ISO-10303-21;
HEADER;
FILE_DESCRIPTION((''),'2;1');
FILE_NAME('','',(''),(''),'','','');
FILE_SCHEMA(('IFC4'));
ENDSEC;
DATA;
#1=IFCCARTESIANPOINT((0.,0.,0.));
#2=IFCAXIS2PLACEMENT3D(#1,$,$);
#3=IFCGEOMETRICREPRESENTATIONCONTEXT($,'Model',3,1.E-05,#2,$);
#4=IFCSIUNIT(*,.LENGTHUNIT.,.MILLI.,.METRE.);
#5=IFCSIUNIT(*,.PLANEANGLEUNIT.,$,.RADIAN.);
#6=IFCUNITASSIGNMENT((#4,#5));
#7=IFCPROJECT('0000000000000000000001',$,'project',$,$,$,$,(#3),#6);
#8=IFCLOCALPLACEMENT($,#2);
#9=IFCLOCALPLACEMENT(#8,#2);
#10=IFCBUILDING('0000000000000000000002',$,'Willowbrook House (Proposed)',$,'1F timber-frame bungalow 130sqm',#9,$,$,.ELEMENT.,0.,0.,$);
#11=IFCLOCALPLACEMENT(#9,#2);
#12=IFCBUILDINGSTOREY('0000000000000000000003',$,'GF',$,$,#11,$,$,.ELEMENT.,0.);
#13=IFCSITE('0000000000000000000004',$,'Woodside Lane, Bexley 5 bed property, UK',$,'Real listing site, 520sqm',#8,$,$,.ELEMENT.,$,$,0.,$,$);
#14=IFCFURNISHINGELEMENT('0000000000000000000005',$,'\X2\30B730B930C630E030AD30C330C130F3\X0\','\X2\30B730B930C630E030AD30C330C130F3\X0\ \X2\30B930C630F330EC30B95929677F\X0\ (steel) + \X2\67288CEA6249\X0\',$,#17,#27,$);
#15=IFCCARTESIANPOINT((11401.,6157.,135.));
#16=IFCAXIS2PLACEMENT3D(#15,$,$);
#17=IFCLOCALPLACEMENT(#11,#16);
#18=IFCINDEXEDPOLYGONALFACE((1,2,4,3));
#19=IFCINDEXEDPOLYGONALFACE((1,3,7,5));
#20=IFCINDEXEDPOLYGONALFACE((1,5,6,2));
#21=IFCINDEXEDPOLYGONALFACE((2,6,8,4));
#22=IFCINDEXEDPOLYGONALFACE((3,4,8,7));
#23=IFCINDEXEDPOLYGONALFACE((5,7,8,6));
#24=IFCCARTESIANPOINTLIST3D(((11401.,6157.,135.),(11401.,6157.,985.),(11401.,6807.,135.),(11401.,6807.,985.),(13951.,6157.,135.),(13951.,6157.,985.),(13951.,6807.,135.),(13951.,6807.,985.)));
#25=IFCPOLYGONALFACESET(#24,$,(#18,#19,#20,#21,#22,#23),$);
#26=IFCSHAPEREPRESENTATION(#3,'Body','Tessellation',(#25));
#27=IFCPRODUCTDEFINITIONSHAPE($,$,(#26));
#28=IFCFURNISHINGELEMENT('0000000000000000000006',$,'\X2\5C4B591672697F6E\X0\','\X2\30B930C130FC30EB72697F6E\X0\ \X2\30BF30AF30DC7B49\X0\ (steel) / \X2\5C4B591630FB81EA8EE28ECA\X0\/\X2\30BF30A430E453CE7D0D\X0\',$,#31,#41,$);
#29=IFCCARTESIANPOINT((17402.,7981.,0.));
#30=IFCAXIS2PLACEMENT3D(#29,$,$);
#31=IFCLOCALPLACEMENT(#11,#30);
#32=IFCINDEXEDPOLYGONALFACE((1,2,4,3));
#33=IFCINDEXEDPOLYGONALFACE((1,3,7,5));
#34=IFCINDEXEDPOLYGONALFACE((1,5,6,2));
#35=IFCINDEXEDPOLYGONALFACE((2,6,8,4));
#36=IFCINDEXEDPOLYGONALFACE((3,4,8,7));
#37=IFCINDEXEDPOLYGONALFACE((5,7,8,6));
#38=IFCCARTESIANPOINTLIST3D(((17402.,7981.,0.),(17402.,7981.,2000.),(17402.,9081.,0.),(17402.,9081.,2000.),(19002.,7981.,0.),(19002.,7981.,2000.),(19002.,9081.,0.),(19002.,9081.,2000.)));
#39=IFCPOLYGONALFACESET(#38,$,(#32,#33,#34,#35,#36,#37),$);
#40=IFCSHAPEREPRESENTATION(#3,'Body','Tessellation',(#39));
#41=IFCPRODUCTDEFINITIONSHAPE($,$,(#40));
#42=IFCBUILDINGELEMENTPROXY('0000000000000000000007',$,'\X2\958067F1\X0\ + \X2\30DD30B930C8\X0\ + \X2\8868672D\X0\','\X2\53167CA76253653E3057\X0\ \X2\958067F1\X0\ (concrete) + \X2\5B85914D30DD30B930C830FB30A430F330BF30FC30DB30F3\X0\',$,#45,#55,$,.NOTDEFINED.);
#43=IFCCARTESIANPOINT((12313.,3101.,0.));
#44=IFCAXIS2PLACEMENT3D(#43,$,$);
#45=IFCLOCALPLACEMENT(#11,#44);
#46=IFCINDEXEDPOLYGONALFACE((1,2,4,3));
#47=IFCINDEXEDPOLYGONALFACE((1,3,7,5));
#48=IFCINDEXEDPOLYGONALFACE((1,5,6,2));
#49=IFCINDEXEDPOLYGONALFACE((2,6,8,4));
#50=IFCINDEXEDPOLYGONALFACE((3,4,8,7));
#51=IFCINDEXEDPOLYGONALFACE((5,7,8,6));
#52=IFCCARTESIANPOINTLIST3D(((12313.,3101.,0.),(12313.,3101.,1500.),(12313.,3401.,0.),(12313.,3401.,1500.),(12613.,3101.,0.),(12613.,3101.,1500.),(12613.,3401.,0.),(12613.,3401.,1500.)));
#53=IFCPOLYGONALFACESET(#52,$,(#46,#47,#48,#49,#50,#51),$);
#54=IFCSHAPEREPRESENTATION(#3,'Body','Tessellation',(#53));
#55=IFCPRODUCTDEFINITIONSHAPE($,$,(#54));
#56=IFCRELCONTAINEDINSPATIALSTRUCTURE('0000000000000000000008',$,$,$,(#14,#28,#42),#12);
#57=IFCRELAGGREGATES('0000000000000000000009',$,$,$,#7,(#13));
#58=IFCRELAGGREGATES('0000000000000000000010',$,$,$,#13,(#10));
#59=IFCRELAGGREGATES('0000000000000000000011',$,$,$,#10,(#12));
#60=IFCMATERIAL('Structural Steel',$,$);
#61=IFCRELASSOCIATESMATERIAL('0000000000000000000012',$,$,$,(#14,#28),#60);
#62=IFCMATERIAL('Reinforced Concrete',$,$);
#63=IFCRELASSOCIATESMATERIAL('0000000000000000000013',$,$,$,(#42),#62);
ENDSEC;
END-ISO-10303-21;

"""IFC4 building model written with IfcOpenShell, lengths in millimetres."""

from ifc_helpers import new_model, si_unit, frame, frame_2d, origin, place, context, project, spatial, rectangle, extrude, material, element, save


model = new_model("IFC4")

# Units and contexts
model_context = context("Model", 3, precision=1e-05, world=origin())
ifc_project = project(units=[si_unit("LENGTHUNIT", "METRE", prefix="MILLI"), si_unit("PLANEANGLEUNIT", "RADIAN")], contexts=[model_context])

# Site, building, storey
site_placement = place(None, origin())
site = spatial("IfcSite", under=ifc_project, at=site_placement, Name="Woodside Lane, Bexley 5 bed property, UK", ObjectType="Real listing site, 520sqm", CompositionType="ELEMENT", RefElevation=0.0)
building_placement = place(site_placement, origin())
building = spatial("IfcBuilding", under=site, at=building_placement, Name="Willowbrook House (Proposed)", ObjectType="1F timber-frame bungalow 130sqm", CompositionType="ELEMENT", ElevationOfRefHeight=0.0, ElevationOfTerrain=0.0)
storey_placement = place(building_placement, origin())
storey = spatial("IfcBuildingStorey", under=building, at=storey_placement, Name="GF", CompositionType="ELEMENT", Elevation=0.0)

# Shared definitions
ifc_material_1 = material(Name="Reinforced Concrete")

# Shared definitions
ifc_material_2 = material(Name="Structural Steel")

# Furnishing elements
furnishing_1_placement = place(storey_placement, frame((11401.0, 6157.0, 135.0)))
element("IfcFurnishingElement", 1, at=furnishing_1_placement, inside=storey, material=ifc_material_2, Name="システムキッチン", Description="システムキッチン ステンレス天板 (steel) + 木質扉", context=model_context, shape_type="SweptSolid", body=[
    extrude(rectangle(XDim=2550.0, YDim=650.0, at=frame_2d((1275.0, 325.0))), frame((11401.0, 6157.0, 135.0)), (0.0, 0.0, 1.0), 850.0),
])
furnishing_2_placement = place(storey_placement, frame((17402.0, 7981.0, 0.0)))
element("IfcFurnishingElement", 2, at=furnishing_2_placement, inside=storey, material=ifc_material_2, Name="屋外物置", Description="スチール物置 タクボ等 (steel) / 屋外・自転車/タイヤ収納", context=model_context, shape_type="SweptSolid", body=[
    extrude(rectangle(XDim=1600.0, YDim=1100.0, at=frame_2d((800.0, 550.0))), frame((17402.0, 7981.0, 0.0)), (0.0, 0.0, 1.0), 2000.0),
])

# Building element proxy
proxy_placement = place(storey_placement, frame((12313.0, 3101.0, 0.0)))
element("IfcBuildingElementProxy", 3, at=proxy_placement, inside=storey, material=ifc_material_1, Name="門柱 + ポスト + 表札", Description="化粧打放し 門柱 (concrete) + 宅配ポスト・インターホン", PredefinedType="NOTDEFINED", context=model_context, shape_type="SweptSolid", body=[
    extrude(rectangle(XDim=300.0, YDim=300.0, at=frame_2d((150.0, 150.0))), frame((12313.0, 3101.0, 0.0)), (0.0, 0.0, 1.0), 1500.0),
])

save(model, "model.ifc")
